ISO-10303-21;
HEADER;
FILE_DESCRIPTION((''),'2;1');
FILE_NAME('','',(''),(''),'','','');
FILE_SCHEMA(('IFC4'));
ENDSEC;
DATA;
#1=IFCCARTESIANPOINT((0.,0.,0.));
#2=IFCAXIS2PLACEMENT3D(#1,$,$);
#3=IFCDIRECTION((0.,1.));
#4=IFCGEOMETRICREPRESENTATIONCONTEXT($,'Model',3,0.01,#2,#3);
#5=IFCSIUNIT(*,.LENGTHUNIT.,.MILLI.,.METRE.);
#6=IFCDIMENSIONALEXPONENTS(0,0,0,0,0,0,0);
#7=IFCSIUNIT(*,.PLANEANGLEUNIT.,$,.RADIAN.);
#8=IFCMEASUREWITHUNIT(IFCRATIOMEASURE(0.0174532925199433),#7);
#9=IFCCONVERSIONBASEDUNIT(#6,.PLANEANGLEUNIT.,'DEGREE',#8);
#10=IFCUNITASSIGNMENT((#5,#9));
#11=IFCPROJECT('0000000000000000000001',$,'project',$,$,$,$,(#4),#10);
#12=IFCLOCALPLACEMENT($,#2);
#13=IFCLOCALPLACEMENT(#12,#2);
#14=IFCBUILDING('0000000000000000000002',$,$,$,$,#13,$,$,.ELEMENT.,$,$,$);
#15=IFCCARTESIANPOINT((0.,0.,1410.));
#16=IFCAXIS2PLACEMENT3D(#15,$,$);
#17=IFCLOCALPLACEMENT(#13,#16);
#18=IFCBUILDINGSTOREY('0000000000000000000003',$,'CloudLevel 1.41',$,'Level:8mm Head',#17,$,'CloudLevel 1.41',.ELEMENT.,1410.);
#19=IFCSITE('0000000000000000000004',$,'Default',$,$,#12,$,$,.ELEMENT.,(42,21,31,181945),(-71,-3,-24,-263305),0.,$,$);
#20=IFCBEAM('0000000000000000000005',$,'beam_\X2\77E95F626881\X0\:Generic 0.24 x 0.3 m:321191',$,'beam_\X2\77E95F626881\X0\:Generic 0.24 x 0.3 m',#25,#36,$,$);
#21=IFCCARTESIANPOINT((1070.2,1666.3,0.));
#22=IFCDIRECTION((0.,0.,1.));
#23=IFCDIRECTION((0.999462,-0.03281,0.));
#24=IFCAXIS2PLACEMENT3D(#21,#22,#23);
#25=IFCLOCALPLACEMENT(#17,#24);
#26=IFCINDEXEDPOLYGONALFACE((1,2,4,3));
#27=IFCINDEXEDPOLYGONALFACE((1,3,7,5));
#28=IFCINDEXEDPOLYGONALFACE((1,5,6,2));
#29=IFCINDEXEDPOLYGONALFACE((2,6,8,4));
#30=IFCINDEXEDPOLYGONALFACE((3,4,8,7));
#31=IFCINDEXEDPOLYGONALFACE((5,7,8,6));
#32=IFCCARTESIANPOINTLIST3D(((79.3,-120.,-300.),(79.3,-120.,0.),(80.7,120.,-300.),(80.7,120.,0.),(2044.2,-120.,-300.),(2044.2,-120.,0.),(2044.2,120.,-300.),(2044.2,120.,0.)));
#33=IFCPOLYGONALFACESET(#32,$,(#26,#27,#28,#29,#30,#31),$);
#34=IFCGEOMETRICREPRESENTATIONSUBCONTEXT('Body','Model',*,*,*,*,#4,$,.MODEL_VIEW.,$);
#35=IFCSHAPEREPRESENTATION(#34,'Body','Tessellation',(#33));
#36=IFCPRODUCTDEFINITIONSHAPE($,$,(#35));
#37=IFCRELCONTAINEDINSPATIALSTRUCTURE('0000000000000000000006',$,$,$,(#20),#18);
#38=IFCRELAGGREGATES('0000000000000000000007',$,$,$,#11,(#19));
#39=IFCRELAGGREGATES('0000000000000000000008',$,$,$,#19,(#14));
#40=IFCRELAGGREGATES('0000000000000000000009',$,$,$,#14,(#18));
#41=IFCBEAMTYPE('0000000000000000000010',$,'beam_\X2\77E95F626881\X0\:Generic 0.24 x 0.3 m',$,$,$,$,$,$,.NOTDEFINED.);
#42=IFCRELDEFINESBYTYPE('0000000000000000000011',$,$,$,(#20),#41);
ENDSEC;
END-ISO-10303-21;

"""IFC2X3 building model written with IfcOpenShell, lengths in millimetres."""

from ifc_helpers import new_model, entity, si_unit, converted_unit, direction, frame, frame_2d, origin, place, context, subcontext, project, spatial, rectangle, extrude, clip, halfspace, type_object, element, save


model = new_model("IFC2X3")

# Units and contexts
model_context = context("Model", 3, precision=0.01, world=origin(), true_north=direction((0.0, 1.0)))
body_context = subcontext(model_context, "Body", "Model", "MODEL_VIEW")
ifc_project = project(units=[si_unit("LENGTHUNIT", "METRE", prefix="MILLI"), converted_unit("PLANEANGLEUNIT", "DEGREE", entity("IfcRatioMeasure", 0.0174532925199433), si_unit("PLANEANGLEUNIT", "RADIAN"), dimensions=[0, 0, 0, 0, 0, 0, 0])], contexts=[model_context])

# Site, building, storey
site_placement = place(None, origin())
site = spatial("IfcSite", under=ifc_project, at=site_placement, Name="Default", CompositionType="ELEMENT", RefLatitude=(42, 21, 31, 181945), RefLongitude=(-71, -3, -24, -263305), RefElevation=0.0)
building_placement = place(site_placement, origin())
building = spatial("IfcBuilding", under=site, at=building_placement, CompositionType="ELEMENT")
storey_placement = place(building_placement, frame((0.0, 0.0, 1410.0)))
storey = spatial("IfcBuildingStorey", under=building, at=storey_placement, Name="CloudLevel 1.41", ObjectType="Level:8mm Head", LongName="CloudLevel 1.41", CompositionType="ELEMENT", Elevation=1410.0)

# Beam
beam_type_1 = type_object("IfcBeamType", Name="beam_矩形梁:Generic 0.24 x 0.3 m", PredefinedType="NOTDEFINED")
beam_1_placement = place(storey_placement, frame((1070.2, 1666.3, 0.0), z_axis=(0.0, 0.0, 1.0), x_axis=(0.999462, -0.03281, 0.0)))
element("IfcBeam", 1, at=beam_1_placement, inside=storey, type_object=beam_type_1, Name="beam_矩形梁:Generic 0.24 x 0.3 m:321191", ObjectType="beam_矩形梁:Generic 0.24 x 0.3 m", context=body_context, shape_type="SweptSolid", body=[
    clip(extrude(rectangle(XDim=300.0, YDim=240.0, at=frame_2d((0.0, 0.0), x_axis=(1.0, 0.0))), frame((79.3, 0.0, -150.0), z_axis=(1.0, 0.0, 0.0), x_axis=(0.0, 0.0, -1.0)), (0.0, 0.0, 1.0), 1964.9), halfspace(frame((91.5, 2120.4, -150.0), z_axis=(-0.999985, 0.005436, 0.0), x_axis=(0.0, 0.0, -1.0)), False)),
])

save(model, "model.ifc")
